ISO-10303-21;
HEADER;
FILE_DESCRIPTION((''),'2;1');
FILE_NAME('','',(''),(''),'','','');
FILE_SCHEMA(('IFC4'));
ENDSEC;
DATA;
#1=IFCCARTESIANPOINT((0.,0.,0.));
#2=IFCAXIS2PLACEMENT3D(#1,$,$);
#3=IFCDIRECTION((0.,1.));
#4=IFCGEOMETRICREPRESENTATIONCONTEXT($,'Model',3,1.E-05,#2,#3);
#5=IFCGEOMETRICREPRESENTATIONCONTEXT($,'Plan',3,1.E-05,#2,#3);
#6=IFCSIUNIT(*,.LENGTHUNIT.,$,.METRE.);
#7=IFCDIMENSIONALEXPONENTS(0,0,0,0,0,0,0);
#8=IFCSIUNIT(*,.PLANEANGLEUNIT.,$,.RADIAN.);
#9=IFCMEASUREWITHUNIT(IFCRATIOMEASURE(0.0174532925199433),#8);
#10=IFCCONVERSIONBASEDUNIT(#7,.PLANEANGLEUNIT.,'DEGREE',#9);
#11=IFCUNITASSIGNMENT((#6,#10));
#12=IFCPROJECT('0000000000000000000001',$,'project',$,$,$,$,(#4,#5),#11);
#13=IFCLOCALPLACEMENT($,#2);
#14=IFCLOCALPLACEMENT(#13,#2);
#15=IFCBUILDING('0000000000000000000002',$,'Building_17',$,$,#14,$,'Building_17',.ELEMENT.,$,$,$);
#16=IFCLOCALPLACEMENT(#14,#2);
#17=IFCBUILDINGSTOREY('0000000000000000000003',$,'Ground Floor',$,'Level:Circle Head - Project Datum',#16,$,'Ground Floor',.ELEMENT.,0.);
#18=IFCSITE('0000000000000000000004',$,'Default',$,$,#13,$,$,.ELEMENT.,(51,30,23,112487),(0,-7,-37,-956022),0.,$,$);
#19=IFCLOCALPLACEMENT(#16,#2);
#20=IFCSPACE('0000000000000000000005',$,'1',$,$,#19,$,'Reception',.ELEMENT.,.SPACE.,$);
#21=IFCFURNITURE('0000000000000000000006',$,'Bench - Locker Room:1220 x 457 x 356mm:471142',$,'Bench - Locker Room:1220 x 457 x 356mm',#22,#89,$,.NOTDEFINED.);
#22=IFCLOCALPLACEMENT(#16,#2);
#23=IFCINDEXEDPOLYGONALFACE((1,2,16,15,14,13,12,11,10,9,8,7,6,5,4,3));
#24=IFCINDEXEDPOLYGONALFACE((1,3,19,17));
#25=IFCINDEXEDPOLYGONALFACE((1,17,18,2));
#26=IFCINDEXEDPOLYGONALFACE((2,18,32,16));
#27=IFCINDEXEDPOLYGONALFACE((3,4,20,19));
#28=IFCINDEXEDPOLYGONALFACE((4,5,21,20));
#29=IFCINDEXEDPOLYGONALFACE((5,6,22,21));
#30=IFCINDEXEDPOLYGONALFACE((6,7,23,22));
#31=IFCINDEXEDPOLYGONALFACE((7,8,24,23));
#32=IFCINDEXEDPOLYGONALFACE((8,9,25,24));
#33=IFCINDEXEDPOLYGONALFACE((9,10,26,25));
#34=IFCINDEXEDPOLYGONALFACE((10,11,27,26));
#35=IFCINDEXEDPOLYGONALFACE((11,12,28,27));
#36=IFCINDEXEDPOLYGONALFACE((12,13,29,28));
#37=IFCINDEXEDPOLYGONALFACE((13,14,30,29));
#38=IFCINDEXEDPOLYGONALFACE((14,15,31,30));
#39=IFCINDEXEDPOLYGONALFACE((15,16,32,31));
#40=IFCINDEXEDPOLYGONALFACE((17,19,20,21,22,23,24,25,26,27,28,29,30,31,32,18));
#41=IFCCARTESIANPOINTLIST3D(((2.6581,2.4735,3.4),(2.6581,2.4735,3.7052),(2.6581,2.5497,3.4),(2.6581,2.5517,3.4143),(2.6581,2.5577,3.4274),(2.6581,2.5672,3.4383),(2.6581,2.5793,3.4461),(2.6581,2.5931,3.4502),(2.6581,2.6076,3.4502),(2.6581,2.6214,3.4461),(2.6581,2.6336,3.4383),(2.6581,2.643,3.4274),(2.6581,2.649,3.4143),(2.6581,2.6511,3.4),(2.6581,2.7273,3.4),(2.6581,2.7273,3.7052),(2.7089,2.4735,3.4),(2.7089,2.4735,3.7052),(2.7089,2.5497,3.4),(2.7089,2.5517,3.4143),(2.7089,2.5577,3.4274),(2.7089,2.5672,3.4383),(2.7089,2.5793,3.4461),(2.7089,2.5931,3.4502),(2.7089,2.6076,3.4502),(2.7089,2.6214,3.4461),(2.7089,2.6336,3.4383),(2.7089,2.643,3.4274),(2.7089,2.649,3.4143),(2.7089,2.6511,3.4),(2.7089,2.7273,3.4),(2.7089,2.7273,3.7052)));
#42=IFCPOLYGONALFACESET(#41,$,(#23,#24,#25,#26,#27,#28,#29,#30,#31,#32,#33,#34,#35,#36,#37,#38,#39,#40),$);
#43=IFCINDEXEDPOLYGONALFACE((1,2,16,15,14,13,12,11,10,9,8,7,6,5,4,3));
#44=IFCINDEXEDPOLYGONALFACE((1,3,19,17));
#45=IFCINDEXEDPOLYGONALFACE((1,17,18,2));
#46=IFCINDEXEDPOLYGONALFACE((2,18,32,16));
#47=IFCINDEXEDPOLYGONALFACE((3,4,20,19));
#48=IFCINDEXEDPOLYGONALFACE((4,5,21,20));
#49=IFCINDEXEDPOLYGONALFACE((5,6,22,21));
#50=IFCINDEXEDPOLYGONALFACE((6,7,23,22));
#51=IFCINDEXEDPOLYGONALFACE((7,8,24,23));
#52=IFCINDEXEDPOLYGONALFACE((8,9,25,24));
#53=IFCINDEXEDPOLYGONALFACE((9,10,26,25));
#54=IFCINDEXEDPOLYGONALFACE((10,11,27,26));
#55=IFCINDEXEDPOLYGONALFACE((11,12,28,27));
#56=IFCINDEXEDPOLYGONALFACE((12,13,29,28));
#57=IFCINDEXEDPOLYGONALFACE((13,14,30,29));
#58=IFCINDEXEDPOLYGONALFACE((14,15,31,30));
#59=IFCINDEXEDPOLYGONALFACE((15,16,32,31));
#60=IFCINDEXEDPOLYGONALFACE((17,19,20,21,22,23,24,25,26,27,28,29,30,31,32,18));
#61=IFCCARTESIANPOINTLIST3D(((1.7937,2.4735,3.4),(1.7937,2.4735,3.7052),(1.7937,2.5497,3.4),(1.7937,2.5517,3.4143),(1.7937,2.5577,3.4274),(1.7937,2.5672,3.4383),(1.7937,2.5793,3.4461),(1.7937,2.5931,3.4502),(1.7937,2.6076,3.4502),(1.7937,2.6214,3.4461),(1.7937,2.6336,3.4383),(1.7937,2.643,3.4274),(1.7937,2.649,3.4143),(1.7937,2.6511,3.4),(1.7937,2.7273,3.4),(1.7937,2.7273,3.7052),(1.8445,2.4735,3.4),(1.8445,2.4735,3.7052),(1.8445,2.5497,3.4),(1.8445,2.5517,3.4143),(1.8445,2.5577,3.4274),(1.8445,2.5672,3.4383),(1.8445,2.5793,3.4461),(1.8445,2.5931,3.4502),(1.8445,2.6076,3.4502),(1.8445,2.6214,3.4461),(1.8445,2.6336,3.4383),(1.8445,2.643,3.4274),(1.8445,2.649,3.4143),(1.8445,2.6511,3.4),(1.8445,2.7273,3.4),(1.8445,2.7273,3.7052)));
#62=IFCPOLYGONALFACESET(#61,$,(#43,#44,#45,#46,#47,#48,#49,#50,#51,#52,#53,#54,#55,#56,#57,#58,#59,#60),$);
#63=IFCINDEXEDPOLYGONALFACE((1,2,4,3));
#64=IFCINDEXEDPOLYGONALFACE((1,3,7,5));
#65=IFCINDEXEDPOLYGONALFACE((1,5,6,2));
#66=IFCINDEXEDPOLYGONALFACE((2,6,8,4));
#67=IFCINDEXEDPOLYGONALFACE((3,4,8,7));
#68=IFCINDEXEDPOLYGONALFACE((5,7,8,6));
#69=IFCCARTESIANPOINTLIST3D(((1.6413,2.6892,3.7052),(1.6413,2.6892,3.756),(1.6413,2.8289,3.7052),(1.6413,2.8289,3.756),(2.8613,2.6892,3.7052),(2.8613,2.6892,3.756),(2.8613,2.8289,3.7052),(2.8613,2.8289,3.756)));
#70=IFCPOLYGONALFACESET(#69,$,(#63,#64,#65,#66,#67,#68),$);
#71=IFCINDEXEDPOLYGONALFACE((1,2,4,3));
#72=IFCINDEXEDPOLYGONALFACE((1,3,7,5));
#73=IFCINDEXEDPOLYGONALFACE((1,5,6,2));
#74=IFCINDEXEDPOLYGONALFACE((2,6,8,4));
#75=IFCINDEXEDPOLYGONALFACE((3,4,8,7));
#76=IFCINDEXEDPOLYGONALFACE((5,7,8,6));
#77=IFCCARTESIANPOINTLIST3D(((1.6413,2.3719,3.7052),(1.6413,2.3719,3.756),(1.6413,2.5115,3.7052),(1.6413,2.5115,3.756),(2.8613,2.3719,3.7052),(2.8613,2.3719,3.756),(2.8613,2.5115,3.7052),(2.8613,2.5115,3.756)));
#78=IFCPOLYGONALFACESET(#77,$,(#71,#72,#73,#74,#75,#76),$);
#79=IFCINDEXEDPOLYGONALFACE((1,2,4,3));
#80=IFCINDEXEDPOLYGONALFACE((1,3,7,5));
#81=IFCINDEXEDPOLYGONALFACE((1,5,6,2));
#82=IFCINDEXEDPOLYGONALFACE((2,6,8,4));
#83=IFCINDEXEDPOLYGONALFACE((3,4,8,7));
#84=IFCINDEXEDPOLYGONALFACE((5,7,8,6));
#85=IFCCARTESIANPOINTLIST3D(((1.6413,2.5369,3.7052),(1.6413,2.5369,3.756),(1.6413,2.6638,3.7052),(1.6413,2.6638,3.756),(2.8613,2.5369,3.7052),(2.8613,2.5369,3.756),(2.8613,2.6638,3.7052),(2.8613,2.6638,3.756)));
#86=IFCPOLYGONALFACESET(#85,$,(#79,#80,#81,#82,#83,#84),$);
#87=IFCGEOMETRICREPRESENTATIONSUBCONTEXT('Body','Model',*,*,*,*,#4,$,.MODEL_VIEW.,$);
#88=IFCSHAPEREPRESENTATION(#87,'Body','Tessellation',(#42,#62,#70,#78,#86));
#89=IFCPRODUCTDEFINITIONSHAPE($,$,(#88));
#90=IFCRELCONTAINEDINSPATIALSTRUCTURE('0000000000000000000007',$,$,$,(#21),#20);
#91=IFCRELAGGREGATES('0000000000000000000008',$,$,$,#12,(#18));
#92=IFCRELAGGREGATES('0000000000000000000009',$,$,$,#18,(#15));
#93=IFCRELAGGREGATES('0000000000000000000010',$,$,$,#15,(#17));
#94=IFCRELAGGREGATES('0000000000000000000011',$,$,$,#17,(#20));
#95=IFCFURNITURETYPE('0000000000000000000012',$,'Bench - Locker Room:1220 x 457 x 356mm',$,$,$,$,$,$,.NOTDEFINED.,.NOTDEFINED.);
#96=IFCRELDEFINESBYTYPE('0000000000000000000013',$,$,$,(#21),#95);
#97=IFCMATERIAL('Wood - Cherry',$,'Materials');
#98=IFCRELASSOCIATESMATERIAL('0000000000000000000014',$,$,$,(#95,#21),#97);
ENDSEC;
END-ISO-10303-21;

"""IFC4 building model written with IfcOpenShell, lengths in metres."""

from ifc_helpers import new_model, entity, si_unit, converted_unit, direction, frame, origin, place, context, subcontext, project, spatial, line, arc, indexed_curve, outline, extrude, source, transform, mapped, material, type_object, type_shapes, element, save


model = new_model("IFC4")

# Units and contexts
model_context = context("Model", 3, precision=1e-05, world=origin(), true_north=direction((0.0, 1.0)))
plan_context = context("Plan", 3, precision=1e-05, world=origin(), true_north=direction((0.0, 1.0)))
body_context = subcontext(model_context, "Body", "Model", "MODEL_VIEW")
ifc_project = project(units=[si_unit("LENGTHUNIT", "METRE"), converted_unit("PLANEANGLEUNIT", "DEGREE", entity("IfcRatioMeasure", 0.0174532925199433), si_unit("PLANEANGLEUNIT", "RADIAN"), dimensions=[0, 0, 0, 0, 0, 0, 0])], contexts=[model_context, plan_context])

# Site, building, storey
site_placement = place(None, origin())
site = spatial("IfcSite", under=ifc_project, at=site_placement, Name="Default", CompositionType="ELEMENT", RefLatitude=(51, 30, 23, 112487), RefLongitude=(0, -7, -37, -956022), RefElevation=0.0)
building_placement = place(site_placement, origin())
building = spatial("IfcBuilding", under=site, at=building_placement, Name="Building_17", LongName="Building_17", CompositionType="ELEMENT")
storey_placement = place(building_placement, origin())
storey = spatial("IfcBuildingStorey", under=building, at=storey_placement, Name="Ground Floor", ObjectType="Level:Circle Head - Project Datum", LongName="Ground Floor", CompositionType="ELEMENT", Elevation=0.0)

# Shared definitions
space_placement = place(storey_placement, origin())
space = spatial("IfcSpace", under=storey, at=space_placement, Name="1", LongName="Reception", CompositionType="ELEMENT", PredefinedType="SPACE")

# Furniture
ifc_material_1 = material(Name="Wood - Cherry", Category="Materials")
furniture_type = type_object("IfcFurnitureType", Name="Bench - Locker Room:1220 x 457 x 356mm", AssemblyPlace="NOTDEFINED", PredefinedType="NOTDEFINED", material=ifc_material_1)
shared_shape_1 = source(origin(), body_context, "Body", "SweptSolid", [
    extrude(outline(indexed_curve([(-0.1269, 0.1017), (-0.1269, -0.2035), (0.1269, -0.2035), (0.1269, 0.1017), (0.0507, 0.1017), (0.0, 0.051), (-0.0507, 0.1017)], segments=[line(1, 2, 3, 4, 5), arc(5, 6, 7), line(7, 1)], self_intersect=False)), frame((0.2515, -0.1807, 0.1017), z_axis=(-1.0, 0.0, 0.0), x_axis=(0.0, 1.0, 0.0)), (0.0, 0.0, -1.0), 0.0508),
    extrude(outline(indexed_curve([(-0.1017, -0.1269), (0.2035, -0.1269), (0.2035, 0.1269), (-0.1017, 0.1269), (-0.1017, 0.0507), (-0.051, 0.0), (-0.1017, -0.0507)], segments=[line(1, 2, 3, 4, 5), arc(5, 6, 7), line(7, 1)], self_intersect=False)), frame((-0.6129, -0.1807, 0.1017), z_axis=(1.0, 0.0, 0.0), x_axis=(0.0, 0.0, 1.0)), (0.0, 0.0, 1.0), 0.0508),
    extrude(outline(indexed_curve([(-0.61, -0.0698), (0.61, -0.0698), (0.61, 0.0698), (-0.61, 0.0698), (-0.61, -0.0698)], self_intersect=False)), frame((-0.1553, -0.022, 0.3052), z_axis=(0.0, 0.0, 1.0), x_axis=(-1.0, 0.0, 0.0)), (0.0, 0.0, 1.0), 0.0508),
    extrude(outline(indexed_curve([(-0.0698, -0.61), (0.0698, -0.61), (0.0698, 0.61), (-0.0698, 0.61), (-0.0698, -0.61)], self_intersect=False)), frame((-0.1553, -0.3394, 0.3052), z_axis=(0.0, 0.0, 1.0), x_axis=(0.0, 1.0, 0.0)), (0.0, 0.0, 1.0), 0.0508),
    extrude(outline(indexed_curve([(-0.61, -0.0635), (0.61, -0.0635), (0.61, 0.0635), (-0.61, 0.0635), (-0.61, -0.0635)], self_intersect=False)), frame((-0.1553, -0.1807, 0.3052), z_axis=(0.0, 0.0, 1.0), x_axis=(-1.0, 0.0, 0.0)), (0.0, 0.0, 1.0), 0.0508),
])
type_shapes(furniture_type, [shared_shape_1])
for number, where, name in (
    (1, (2.4066, 2.7811, 3.4), "Bench - Locker Room:1220 x 457 x 356mm:471142"),
):
    element("IfcFurniture", number, at=place(space_placement, frame(where)), inside=space, type_object=furniture_type, material=ifc_material_1, Name=name, ObjectType="Bench - Locker Room:1220 x 457 x 356mm", PredefinedType="NOTDEFINED", context=body_context, shape_type="MappedRepresentation", body=[
        mapped(shared_shape_1, transform((0.0, 0.0, 0.0), scale=1.0)),
    ])

save(model, "model.ifc")
